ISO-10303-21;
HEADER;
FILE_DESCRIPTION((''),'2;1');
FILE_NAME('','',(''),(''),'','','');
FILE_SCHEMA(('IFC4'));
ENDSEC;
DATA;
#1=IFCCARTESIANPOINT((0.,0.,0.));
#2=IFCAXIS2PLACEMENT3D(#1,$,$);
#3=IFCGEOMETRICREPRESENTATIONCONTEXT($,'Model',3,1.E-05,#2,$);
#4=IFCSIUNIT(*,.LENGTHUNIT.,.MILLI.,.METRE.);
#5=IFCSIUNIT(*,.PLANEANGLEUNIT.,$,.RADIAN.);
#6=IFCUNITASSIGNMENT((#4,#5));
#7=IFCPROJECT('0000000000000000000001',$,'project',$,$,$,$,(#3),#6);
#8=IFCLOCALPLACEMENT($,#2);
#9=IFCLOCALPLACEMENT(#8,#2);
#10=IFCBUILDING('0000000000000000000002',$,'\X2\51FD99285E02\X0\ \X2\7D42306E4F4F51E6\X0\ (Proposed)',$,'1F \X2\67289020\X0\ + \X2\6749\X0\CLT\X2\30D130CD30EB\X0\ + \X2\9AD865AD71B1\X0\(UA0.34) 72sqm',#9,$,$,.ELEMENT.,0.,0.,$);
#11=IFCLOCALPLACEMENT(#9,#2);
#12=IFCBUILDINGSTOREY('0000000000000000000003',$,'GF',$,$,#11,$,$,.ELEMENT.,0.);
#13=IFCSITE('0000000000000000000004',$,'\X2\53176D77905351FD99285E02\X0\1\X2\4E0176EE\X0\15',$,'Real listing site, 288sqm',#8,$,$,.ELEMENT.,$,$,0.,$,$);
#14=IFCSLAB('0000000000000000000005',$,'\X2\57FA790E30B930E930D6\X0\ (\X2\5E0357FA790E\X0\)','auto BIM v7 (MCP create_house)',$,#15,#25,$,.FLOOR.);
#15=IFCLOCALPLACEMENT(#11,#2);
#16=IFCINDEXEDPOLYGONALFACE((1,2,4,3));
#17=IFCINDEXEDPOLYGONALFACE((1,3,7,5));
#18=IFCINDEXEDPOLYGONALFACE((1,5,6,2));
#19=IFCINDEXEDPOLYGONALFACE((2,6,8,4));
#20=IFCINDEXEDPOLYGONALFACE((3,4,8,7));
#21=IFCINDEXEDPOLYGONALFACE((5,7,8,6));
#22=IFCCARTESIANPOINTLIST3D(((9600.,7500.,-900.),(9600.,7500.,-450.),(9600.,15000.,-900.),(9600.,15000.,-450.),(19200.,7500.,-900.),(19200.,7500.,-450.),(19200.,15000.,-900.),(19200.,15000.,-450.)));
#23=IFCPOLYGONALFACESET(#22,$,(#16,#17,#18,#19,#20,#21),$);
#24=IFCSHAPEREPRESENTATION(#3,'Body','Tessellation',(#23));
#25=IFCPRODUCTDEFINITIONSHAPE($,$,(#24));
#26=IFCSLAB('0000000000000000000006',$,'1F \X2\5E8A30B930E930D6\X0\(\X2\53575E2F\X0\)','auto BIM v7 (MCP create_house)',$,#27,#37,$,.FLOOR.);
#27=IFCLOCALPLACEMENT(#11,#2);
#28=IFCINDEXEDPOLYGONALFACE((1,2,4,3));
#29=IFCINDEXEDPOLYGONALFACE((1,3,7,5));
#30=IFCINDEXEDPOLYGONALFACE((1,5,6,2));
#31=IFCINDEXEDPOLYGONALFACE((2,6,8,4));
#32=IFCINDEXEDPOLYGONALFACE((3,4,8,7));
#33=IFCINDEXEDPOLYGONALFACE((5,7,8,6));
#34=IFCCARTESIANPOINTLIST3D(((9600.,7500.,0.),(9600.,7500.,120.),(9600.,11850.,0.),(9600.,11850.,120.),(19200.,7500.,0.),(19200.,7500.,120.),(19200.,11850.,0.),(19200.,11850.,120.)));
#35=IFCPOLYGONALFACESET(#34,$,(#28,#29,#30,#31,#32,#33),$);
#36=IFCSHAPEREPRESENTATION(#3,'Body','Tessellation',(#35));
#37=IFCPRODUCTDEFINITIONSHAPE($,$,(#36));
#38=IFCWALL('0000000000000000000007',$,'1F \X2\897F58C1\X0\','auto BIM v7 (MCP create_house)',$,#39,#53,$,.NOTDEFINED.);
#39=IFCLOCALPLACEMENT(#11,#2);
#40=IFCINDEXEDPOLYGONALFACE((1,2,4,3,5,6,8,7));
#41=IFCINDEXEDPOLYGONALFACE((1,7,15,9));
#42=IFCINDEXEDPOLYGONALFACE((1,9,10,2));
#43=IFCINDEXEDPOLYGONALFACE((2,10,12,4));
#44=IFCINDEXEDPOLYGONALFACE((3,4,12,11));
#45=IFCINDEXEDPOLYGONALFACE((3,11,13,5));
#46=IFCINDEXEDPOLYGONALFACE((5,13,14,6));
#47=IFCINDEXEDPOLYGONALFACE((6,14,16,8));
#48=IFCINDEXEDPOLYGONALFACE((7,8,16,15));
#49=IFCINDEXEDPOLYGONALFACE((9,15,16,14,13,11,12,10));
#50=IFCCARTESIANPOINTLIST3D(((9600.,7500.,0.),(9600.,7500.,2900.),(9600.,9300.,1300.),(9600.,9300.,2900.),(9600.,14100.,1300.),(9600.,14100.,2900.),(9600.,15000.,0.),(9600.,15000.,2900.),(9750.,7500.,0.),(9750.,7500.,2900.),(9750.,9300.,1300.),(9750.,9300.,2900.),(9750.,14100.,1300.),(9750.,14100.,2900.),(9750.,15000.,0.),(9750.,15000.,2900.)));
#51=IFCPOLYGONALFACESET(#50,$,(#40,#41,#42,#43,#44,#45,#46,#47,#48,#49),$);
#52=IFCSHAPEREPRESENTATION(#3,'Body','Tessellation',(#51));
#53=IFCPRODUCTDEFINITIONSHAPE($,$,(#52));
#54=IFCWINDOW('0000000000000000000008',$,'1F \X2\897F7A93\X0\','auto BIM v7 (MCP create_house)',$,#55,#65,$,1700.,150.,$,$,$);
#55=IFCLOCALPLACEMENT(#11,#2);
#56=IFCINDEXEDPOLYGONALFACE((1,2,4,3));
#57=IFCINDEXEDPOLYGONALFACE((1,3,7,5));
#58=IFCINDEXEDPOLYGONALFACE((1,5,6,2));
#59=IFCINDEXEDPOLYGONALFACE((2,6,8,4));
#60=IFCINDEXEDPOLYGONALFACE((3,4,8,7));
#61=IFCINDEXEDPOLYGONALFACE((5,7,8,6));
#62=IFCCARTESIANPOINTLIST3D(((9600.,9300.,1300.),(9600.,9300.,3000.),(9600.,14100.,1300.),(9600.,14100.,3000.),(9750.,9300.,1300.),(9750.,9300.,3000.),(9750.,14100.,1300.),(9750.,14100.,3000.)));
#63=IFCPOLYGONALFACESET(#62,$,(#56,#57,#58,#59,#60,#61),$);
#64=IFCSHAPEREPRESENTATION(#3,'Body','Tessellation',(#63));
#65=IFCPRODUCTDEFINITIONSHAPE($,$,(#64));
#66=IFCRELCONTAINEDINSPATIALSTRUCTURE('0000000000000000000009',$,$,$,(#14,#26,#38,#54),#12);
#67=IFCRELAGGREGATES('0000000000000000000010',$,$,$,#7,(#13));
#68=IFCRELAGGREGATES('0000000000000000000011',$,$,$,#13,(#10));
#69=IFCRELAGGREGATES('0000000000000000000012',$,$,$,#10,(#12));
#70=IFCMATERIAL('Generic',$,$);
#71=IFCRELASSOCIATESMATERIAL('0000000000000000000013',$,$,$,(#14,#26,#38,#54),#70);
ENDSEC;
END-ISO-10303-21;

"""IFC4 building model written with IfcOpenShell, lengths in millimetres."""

from ifc_helpers import new_model, si_unit, frame, frame_2d, origin, place, context, project, spatial, rectangle, extrude, material, element, fill, save


model = new_model("IFC4")

# Units and contexts
model_context = context("Model", 3, precision=1e-05, world=origin())
ifc_project = project(units=[si_unit("LENGTHUNIT", "METRE", prefix="MILLI"), si_unit("PLANEANGLEUNIT", "RADIAN")], contexts=[model_context])

# Site, building, storey
site_placement = place(None, origin())
site = spatial("IfcSite", under=ifc_project, at=site_placement, Name="北海道函館市1丁目15", ObjectType="Real listing site, 288sqm", CompositionType="ELEMENT", RefElevation=0.0)
building_placement = place(site_placement, origin())
building = spatial("IfcBuilding", under=site, at=building_placement, Name="函館市 終の住処 (Proposed)", ObjectType="1F 木造 + 杉CLTパネル + 高断熱(UA0.34) 72sqm", CompositionType="ELEMENT", ElevationOfRefHeight=0.0, ElevationOfTerrain=0.0)
storey_placement = place(building_placement, origin())
storey = spatial("IfcBuildingStorey", under=building, at=storey_placement, Name="GF", CompositionType="ELEMENT", Elevation=0.0)

# Slabs
ifc_material = material(Name="Generic")
slab_1_placement = place(storey_placement, frame((4800.0, 3750.0, -450.0)))
element("IfcSlab", 1, at=slab_1_placement, inside=storey, material=ifc_material, Name="基礎スラブ (布基礎)", Description="auto BIM v7 (MCP create_house)", PredefinedType="FLOOR", context=model_context, shape_type="SweptSolid", body=[
    extrude(rectangle(XDim=9600.0, YDim=7500.0, at=frame_2d((4800.0, 3750.0))), frame((4800.0, 3750.0, -450.0)), (0.0, 0.0, 1.0), 450.0),
])
slab_2_placement = place(storey_placement, frame((4800.0, 3750.0, 0.0)))
element("IfcSlab", 2, at=slab_2_placement, inside=storey, material=ifc_material, Name="1F 床スラブ(南帯)", Description="auto BIM v7 (MCP create_house)", PredefinedType="FLOOR", context=model_context, shape_type="SweptSolid", body=[
    extrude(rectangle(XDim=9600.0, YDim=4350.0, at=frame_2d((4800.0, 2175.0))), frame((4800.0, 3750.0, 0.0)), (0.0, 0.0, 1.0), 120.0),
])

# Wall, opening, window
wall_1_placement = place(storey_placement, frame((4800.0, 3750.0, 0.0)))
wall_1 = element("IfcWall", 3, at=wall_1_placement, inside=storey, material=ifc_material, Name="1F 西壁", Description="auto BIM v7 (MCP create_house)", PredefinedType="NOTDEFINED", context=model_context, shape_type="SweptSolid", body=[
    extrude(rectangle(XDim=150.0, YDim=7500.0, at=frame_2d((75.0, 3750.0))), frame((4800.0, 3750.0, 0.0)), (0.0, 0.0, 1.0), 2900.0),
])
opening_1_placement = place(storey_placement, frame((4800.0, 4650.0, 650.0)))
opening_1 = element("IfcOpeningElement", 4, at=opening_1_placement, cuts=wall_1, PredefinedType="NOTDEFINED", context=model_context, shape_type="SweptSolid", body=[
    extrude(rectangle(XDim=150.0, YDim=4800.0, at=frame_2d((75.0, 2400.0))), frame((4800.0, 4650.0, 650.0)), (0.0, 0.0, 1.0), 1700.0),
])
window_1_placement = place(storey_placement, frame((4800.0, 4650.0, 650.0)))
window_1 = element("IfcWindow", 5, at=window_1_placement, inside=storey, material=ifc_material, Name="1F 西窓", Description="auto BIM v7 (MCP create_house)", OverallHeight=1700.0, OverallWidth=150.0, context=model_context, shape_type="SweptSolid", body=[
    extrude(rectangle(XDim=150.0, YDim=4800.0, at=frame_2d((75.0, 2400.0))), frame((4800.0, 4650.0, 650.0)), (0.0, 0.0, 1.0), 1700.0),
])
fill(opening_1, window_1)

save(model, "model.ifc")
